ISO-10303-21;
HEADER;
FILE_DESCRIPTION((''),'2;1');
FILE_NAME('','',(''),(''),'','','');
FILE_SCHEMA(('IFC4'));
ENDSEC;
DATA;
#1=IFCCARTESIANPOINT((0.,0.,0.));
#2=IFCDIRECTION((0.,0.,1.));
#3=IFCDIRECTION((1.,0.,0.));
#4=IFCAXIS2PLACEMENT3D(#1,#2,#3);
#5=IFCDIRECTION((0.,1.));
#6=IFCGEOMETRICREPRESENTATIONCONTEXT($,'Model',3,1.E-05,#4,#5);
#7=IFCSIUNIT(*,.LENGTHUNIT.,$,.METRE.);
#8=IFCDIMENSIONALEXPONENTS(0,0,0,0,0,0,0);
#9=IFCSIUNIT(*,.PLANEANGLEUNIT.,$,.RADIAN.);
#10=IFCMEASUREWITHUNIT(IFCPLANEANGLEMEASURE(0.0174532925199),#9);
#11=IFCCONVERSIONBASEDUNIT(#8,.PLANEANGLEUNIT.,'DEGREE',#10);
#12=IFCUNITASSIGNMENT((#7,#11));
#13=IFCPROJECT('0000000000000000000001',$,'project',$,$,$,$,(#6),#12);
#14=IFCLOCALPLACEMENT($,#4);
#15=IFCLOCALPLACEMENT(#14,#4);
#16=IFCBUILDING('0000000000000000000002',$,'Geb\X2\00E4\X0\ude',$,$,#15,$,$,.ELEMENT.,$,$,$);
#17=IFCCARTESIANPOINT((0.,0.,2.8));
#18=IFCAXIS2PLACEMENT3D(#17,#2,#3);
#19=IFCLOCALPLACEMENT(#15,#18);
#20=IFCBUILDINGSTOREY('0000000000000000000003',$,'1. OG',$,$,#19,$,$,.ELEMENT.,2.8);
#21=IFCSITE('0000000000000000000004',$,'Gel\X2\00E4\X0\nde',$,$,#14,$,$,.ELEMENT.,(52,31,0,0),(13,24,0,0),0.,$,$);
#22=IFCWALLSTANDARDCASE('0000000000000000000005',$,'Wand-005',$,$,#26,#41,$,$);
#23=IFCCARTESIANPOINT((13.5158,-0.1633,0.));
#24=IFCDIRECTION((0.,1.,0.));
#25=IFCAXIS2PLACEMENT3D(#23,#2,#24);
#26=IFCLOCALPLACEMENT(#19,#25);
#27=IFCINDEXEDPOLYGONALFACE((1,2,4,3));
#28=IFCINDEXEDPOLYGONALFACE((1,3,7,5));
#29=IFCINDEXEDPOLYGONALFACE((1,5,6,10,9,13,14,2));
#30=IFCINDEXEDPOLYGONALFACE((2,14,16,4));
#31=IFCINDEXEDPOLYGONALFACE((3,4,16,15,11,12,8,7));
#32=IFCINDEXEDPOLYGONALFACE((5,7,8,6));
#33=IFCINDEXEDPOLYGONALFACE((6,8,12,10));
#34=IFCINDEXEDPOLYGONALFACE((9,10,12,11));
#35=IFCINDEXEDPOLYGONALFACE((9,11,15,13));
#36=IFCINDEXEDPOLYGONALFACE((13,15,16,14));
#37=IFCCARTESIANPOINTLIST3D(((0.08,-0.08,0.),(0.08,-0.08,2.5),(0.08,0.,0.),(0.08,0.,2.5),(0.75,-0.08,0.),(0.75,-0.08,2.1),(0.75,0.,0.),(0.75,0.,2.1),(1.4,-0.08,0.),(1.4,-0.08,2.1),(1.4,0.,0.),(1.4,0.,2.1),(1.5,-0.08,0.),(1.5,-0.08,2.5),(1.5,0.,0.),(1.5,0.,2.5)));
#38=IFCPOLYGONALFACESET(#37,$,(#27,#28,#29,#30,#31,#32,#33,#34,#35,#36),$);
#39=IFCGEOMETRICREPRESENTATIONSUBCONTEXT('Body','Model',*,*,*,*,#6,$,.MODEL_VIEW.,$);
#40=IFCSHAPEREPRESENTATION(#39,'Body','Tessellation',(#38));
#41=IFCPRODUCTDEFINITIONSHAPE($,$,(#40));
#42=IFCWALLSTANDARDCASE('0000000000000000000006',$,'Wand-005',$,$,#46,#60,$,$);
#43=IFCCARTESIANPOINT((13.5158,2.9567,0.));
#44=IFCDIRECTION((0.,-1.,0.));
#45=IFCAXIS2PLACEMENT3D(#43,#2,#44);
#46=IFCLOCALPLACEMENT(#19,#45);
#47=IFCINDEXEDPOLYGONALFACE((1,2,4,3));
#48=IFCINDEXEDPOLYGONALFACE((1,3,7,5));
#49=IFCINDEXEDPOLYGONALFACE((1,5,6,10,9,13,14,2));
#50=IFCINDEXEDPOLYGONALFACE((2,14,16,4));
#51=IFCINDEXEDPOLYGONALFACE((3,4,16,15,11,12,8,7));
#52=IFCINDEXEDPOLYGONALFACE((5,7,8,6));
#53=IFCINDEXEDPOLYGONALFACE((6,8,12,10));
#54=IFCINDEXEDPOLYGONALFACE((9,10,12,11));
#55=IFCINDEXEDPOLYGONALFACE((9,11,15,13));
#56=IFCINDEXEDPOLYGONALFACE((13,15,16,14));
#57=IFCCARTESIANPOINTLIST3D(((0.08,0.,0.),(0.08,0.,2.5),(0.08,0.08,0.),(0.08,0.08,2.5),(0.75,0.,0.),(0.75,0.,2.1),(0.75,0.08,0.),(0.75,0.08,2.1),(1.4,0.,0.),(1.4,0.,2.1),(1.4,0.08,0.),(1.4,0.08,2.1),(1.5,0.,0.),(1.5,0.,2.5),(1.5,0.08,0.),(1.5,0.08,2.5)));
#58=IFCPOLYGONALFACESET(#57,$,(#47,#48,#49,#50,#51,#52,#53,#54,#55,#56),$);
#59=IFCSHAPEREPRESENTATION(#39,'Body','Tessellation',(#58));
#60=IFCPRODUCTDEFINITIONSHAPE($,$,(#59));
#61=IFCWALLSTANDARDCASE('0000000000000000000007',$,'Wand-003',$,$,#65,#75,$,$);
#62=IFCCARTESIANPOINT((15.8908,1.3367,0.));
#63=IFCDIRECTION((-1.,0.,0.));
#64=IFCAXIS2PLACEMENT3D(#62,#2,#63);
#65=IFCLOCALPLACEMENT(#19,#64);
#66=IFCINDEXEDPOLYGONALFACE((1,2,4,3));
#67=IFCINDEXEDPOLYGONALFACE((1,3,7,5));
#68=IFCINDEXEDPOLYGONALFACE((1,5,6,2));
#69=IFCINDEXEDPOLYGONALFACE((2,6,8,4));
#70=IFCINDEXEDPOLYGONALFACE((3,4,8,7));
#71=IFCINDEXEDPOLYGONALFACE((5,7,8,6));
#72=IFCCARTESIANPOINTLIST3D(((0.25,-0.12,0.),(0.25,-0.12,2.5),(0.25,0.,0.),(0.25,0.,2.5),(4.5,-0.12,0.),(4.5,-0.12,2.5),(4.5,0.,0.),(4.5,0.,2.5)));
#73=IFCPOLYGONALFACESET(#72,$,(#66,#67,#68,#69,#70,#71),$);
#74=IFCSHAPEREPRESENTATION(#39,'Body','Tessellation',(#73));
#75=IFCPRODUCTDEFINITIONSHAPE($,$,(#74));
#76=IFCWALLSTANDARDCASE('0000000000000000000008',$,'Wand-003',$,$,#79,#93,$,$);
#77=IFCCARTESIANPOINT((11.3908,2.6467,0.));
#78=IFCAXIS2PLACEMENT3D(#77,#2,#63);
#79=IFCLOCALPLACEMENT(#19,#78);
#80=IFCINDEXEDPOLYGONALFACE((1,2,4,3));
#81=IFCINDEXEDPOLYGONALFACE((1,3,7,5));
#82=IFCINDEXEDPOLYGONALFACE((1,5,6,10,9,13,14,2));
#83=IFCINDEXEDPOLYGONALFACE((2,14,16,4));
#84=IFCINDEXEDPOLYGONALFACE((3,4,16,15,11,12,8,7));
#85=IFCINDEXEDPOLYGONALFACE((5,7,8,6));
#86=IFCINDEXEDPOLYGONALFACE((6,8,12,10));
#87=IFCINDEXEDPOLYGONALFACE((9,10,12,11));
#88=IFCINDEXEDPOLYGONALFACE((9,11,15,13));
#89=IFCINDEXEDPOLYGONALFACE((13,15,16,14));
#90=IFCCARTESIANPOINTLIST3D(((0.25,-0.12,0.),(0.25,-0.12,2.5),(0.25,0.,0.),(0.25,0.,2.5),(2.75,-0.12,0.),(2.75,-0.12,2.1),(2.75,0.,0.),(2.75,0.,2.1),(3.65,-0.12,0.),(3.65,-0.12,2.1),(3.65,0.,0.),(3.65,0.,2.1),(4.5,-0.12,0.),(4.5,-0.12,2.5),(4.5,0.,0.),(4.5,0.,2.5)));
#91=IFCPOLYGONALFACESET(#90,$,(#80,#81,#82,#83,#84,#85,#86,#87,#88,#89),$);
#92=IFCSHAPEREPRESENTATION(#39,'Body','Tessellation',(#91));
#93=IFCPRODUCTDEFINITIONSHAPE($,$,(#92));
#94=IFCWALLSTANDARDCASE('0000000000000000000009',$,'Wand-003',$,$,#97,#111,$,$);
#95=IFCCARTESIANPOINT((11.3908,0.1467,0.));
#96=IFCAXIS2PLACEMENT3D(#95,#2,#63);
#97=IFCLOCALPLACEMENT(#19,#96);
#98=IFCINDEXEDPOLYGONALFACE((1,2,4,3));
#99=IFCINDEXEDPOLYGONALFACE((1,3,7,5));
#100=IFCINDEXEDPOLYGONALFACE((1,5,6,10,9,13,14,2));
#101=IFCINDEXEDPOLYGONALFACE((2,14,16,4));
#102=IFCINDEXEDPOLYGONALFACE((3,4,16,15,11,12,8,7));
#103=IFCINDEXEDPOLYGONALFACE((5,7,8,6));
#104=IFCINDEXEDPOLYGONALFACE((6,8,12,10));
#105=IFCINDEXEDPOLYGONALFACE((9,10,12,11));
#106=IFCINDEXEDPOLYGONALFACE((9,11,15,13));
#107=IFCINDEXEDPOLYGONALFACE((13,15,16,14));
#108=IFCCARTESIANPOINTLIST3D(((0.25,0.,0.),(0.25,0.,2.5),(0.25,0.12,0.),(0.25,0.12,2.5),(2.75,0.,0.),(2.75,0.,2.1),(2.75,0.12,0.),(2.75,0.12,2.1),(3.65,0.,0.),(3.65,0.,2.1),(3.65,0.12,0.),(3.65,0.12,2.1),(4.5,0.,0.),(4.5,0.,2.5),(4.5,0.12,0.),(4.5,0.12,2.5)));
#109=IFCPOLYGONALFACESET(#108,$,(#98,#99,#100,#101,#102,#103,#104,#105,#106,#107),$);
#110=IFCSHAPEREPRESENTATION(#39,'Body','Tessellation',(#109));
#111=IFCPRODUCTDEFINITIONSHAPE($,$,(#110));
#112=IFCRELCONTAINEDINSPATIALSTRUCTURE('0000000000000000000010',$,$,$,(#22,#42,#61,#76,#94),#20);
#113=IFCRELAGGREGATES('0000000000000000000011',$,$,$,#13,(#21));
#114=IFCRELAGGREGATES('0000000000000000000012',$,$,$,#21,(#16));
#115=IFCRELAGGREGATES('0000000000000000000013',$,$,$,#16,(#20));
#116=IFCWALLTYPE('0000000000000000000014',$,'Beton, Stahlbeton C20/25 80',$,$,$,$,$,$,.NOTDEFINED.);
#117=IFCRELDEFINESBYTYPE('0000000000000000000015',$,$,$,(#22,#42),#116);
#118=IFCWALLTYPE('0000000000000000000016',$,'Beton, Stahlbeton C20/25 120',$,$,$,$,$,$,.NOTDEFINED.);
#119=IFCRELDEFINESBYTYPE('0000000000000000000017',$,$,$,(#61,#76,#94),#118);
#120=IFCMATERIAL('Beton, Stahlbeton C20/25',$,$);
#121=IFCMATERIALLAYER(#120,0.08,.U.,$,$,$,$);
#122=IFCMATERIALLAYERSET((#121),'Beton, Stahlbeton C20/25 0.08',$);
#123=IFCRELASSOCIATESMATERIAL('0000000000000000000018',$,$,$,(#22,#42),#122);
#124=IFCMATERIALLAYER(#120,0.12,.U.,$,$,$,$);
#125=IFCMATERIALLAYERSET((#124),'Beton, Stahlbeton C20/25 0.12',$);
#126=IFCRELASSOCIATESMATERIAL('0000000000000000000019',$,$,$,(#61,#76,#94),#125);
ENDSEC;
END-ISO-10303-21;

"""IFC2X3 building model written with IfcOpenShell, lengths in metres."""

from ifc_helpers import new_model, entity, si_unit, converted_unit, direction, frame, origin_with_axes, origin_2d_with_axis, place, context, subcontext, project, spatial, polyline, rectangle, outline, extrude, material, layer, layer_set, layer_usage, type_object, element, save


model = new_model("IFC2X3")

# Units and contexts
model_context = context("Model", 3, precision=1e-05, world=origin_with_axes(), true_north=direction((0.0, 1.0)))
body_context = subcontext(model_context, "Body", "Model", "MODEL_VIEW")
ifc_project = project(units=[si_unit("LENGTHUNIT", "METRE"), converted_unit("PLANEANGLEUNIT", "DEGREE", entity("IfcPlaneAngleMeasure", 0.0174532925199), si_unit("PLANEANGLEUNIT", "RADIAN"), dimensions=[0, 0, 0, 0, 0, 0, 0])], contexts=[model_context])

# Site, building, storey
site_placement = place(None, origin_with_axes())
site = spatial("IfcSite", under=ifc_project, at=site_placement, Name="Gelände", CompositionType="ELEMENT", RefLatitude=(52, 31, 0, 0), RefLongitude=(13, 24, 0, 0), RefElevation=0.0)
building_placement = place(site_placement, origin_with_axes())
building = spatial("IfcBuilding", under=site, at=building_placement, Name="Gebäude", CompositionType="ELEMENT")
storey_placement = place(building_placement, frame((0.0, 0.0, 2.8), z_axis=(0.0, 0.0, 1.0), x_axis=(1.0, 0.0, 0.0)))
storey = spatial("IfcBuildingStorey", under=building, at=storey_placement, Name="1. OG", CompositionType="ELEMENT", Elevation=2.8)

# Shared definitions
ifc_material_1 = material(Name="Beton, Stahlbeton C20/25")
ifc_layer_1 = layer(ifc_material_1, 0.08, ventilated="UNKNOWN")
ifc_layer_set_1 = layer_set([ifc_layer_1], Name="Beton, Stahlbeton C20/25 0.08")
wall_type_1 = type_object("IfcWallType", Name="Beton, Stahlbeton C20/25 80", PredefinedType="NOTDEFINED")

# Walls, openings
ifc_layer_usage_1 = layer_usage(ifc_layer_set_1, "AXIS2", "NEGATIVE", 0.0)
wall_1_placement = place(storey_placement, frame((13.5158, -0.1633, 0.0), z_axis=(0.0, 0.0, 1.0), x_axis=(0.0, 1.0, 0.0)))
wall_1 = element("IfcWallStandardCase", 1, at=wall_1_placement, inside=storey, type_object=wall_type_1, material=ifc_layer_usage_1, Name="Wand-005", context=body_context, shape_type="SweptSolid", body=[
    extrude(outline(polyline([(0.08, -0.08), (1.5, -0.08), (1.5, 0.0), (0.08, 0.0), (0.08, -0.08)])), origin_with_axes(), (0.0, 0.0, 1.0), 2.5),
])
opening_1_placement = place(wall_1_placement, frame((1.075, 0.0, 0.0), z_axis=(0.0, 0.0, 1.0), x_axis=(1.0, 0.0, 0.0)))
element("IfcOpeningElement", 2, at=opening_1_placement, cuts=wall_1, context=body_context, shape_type="SweptSolid", body=[
    extrude(rectangle(XDim=0.65, YDim=2.1, at=origin_2d_with_axis()), frame((0.0, 0.08, 1.05), z_axis=(0.0, 1.0, 0.0), x_axis=(-1.0, 0.0, 0.0)), (0.0, 0.0, -1.0), 0.24),
])
ifc_layer_usage_2 = layer_usage(ifc_layer_set_1, "AXIS2", "POSITIVE", 0.0)
wall_2_placement = place(storey_placement, frame((13.5158, 2.9567, 0.0), z_axis=(0.0, 0.0, 1.0), x_axis=(0.0, -1.0, 0.0)))
wall_2 = element("IfcWallStandardCase", 3, at=wall_2_placement, inside=storey, type_object=wall_type_1, material=ifc_layer_usage_2, Name="Wand-005", context=body_context, shape_type="SweptSolid", body=[
    extrude(outline(polyline([(0.08, 0.0), (1.5, 0.0), (1.5, 0.08), (0.08, 0.08), (0.08, 0.0)])), origin_with_axes(), (0.0, 0.0, 1.0), 2.5),
])
opening_2_placement = place(wall_2_placement, frame((1.075, 0.0, 0.0), z_axis=(0.0, 0.0, 1.0), x_axis=(1.0, 0.0, 0.0)))
element("IfcOpeningElement", 4, at=opening_2_placement, cuts=wall_2, context=body_context, shape_type="SweptSolid", body=[
    extrude(rectangle(XDim=0.65, YDim=2.1, at=origin_2d_with_axis()), frame((0.0, -0.08, 1.05), z_axis=(0.0, 1.0, 0.0), x_axis=(-1.0, 0.0, 0.0)), (0.0, 0.0, 1.0), 0.24),
])

# Wall
ifc_layer_2 = layer(ifc_material_1, 0.12, ventilated="UNKNOWN")
ifc_layer_set_2 = layer_set([ifc_layer_2], Name="Beton, Stahlbeton C20/25 0.12")
ifc_layer_usage_3 = layer_usage(ifc_layer_set_2, "AXIS2", "NEGATIVE", 0.0)
wall_type_2 = type_object("IfcWallType", Name="Beton, Stahlbeton C20/25 120", PredefinedType="NOTDEFINED")
wall_3_placement = place(storey_placement, frame((15.8908, 1.3367, 0.0), z_axis=(0.0, 0.0, 1.0), x_axis=(-1.0, 0.0, 0.0)))
element("IfcWallStandardCase", 5, at=wall_3_placement, inside=storey, type_object=wall_type_2, material=ifc_layer_usage_3, Name="Wand-003", context=body_context, shape_type="SweptSolid", body=[
    extrude(outline(polyline([(0.25, -0.12), (4.5, -0.12), (4.5, 0.0), (0.25, 0.0), (0.25, -0.12)])), origin_with_axes(), (0.0, 0.0, 1.0), 2.5),
])

# Walls, openings
ifc_layer_usage_4 = layer_usage(ifc_layer_set_2, "AXIS2", "NEGATIVE", 0.0)
wall_4_placement = place(storey_placement, frame((11.3908, 2.6467, 0.0), z_axis=(0.0, 0.0, 1.0), x_axis=(-1.0, 0.0, 0.0)))
wall_4 = element("IfcWallStandardCase", 6, at=wall_4_placement, inside=storey, type_object=wall_type_2, material=ifc_layer_usage_4, Name="Wand-003", context=body_context, shape_type="SweptSolid", body=[
    extrude(outline(polyline([(0.25, -0.12), (4.5, -0.12), (4.5, 0.0), (0.25, 0.0), (0.25, -0.12)])), origin_with_axes(), (0.0, 0.0, 1.0), 2.5),
])
opening_3_placement = place(wall_4_placement, frame((3.2, 0.0, 0.0), z_axis=(0.0, 0.0, 1.0), x_axis=(1.0, 0.0, 0.0)))
element("IfcOpeningElement", 7, at=opening_3_placement, cuts=wall_4, context=body_context, shape_type="SweptSolid", body=[
    extrude(rectangle(XDim=0.9, YDim=2.1, at=origin_2d_with_axis()), frame((0.0, -0.24, 1.05), z_axis=(0.0, 1.0, 0.0), x_axis=(-1.0, 0.0, 0.0)), (0.0, 0.0, 1.0), 0.36),
])
ifc_layer_usage_5 = layer_usage(ifc_layer_set_2, "AXIS2", "POSITIVE", 0.0)
wall_5_placement = place(storey_placement, frame((11.3908, 0.1467, 0.0), z_axis=(0.0, 0.0, 1.0), x_axis=(-1.0, 0.0, 0.0)))
wall_5 = element("IfcWallStandardCase", 8, at=wall_5_placement, inside=storey, type_object=wall_type_2, material=ifc_layer_usage_5, Name="Wand-003", context=body_context, shape_type="SweptSolid", body=[
    extrude(outline(polyline([(0.25, 0.0), (4.5, 0.0), (4.5, 0.12), (0.25, 0.12), (0.25, 0.0)])), origin_with_axes(), (0.0, 0.0, 1.0), 2.5),
])
opening_4_placement = place(wall_5_placement, frame((3.2, 0.0, 0.0), z_axis=(0.0, 0.0, 1.0), x_axis=(1.0, 0.0, 0.0)))
element("IfcOpeningElement", 9, at=opening_4_placement, cuts=wall_5, context=body_context, shape_type="SweptSolid", body=[
    extrude(rectangle(XDim=0.9, YDim=2.1, at=origin_2d_with_axis()), frame((0.0, 0.24, 1.05), z_axis=(0.0, 1.0, 0.0), x_axis=(-1.0, 0.0, 0.0)), (0.0, 0.0, -1.0), 0.36),
])

save(model, "model.ifc")
